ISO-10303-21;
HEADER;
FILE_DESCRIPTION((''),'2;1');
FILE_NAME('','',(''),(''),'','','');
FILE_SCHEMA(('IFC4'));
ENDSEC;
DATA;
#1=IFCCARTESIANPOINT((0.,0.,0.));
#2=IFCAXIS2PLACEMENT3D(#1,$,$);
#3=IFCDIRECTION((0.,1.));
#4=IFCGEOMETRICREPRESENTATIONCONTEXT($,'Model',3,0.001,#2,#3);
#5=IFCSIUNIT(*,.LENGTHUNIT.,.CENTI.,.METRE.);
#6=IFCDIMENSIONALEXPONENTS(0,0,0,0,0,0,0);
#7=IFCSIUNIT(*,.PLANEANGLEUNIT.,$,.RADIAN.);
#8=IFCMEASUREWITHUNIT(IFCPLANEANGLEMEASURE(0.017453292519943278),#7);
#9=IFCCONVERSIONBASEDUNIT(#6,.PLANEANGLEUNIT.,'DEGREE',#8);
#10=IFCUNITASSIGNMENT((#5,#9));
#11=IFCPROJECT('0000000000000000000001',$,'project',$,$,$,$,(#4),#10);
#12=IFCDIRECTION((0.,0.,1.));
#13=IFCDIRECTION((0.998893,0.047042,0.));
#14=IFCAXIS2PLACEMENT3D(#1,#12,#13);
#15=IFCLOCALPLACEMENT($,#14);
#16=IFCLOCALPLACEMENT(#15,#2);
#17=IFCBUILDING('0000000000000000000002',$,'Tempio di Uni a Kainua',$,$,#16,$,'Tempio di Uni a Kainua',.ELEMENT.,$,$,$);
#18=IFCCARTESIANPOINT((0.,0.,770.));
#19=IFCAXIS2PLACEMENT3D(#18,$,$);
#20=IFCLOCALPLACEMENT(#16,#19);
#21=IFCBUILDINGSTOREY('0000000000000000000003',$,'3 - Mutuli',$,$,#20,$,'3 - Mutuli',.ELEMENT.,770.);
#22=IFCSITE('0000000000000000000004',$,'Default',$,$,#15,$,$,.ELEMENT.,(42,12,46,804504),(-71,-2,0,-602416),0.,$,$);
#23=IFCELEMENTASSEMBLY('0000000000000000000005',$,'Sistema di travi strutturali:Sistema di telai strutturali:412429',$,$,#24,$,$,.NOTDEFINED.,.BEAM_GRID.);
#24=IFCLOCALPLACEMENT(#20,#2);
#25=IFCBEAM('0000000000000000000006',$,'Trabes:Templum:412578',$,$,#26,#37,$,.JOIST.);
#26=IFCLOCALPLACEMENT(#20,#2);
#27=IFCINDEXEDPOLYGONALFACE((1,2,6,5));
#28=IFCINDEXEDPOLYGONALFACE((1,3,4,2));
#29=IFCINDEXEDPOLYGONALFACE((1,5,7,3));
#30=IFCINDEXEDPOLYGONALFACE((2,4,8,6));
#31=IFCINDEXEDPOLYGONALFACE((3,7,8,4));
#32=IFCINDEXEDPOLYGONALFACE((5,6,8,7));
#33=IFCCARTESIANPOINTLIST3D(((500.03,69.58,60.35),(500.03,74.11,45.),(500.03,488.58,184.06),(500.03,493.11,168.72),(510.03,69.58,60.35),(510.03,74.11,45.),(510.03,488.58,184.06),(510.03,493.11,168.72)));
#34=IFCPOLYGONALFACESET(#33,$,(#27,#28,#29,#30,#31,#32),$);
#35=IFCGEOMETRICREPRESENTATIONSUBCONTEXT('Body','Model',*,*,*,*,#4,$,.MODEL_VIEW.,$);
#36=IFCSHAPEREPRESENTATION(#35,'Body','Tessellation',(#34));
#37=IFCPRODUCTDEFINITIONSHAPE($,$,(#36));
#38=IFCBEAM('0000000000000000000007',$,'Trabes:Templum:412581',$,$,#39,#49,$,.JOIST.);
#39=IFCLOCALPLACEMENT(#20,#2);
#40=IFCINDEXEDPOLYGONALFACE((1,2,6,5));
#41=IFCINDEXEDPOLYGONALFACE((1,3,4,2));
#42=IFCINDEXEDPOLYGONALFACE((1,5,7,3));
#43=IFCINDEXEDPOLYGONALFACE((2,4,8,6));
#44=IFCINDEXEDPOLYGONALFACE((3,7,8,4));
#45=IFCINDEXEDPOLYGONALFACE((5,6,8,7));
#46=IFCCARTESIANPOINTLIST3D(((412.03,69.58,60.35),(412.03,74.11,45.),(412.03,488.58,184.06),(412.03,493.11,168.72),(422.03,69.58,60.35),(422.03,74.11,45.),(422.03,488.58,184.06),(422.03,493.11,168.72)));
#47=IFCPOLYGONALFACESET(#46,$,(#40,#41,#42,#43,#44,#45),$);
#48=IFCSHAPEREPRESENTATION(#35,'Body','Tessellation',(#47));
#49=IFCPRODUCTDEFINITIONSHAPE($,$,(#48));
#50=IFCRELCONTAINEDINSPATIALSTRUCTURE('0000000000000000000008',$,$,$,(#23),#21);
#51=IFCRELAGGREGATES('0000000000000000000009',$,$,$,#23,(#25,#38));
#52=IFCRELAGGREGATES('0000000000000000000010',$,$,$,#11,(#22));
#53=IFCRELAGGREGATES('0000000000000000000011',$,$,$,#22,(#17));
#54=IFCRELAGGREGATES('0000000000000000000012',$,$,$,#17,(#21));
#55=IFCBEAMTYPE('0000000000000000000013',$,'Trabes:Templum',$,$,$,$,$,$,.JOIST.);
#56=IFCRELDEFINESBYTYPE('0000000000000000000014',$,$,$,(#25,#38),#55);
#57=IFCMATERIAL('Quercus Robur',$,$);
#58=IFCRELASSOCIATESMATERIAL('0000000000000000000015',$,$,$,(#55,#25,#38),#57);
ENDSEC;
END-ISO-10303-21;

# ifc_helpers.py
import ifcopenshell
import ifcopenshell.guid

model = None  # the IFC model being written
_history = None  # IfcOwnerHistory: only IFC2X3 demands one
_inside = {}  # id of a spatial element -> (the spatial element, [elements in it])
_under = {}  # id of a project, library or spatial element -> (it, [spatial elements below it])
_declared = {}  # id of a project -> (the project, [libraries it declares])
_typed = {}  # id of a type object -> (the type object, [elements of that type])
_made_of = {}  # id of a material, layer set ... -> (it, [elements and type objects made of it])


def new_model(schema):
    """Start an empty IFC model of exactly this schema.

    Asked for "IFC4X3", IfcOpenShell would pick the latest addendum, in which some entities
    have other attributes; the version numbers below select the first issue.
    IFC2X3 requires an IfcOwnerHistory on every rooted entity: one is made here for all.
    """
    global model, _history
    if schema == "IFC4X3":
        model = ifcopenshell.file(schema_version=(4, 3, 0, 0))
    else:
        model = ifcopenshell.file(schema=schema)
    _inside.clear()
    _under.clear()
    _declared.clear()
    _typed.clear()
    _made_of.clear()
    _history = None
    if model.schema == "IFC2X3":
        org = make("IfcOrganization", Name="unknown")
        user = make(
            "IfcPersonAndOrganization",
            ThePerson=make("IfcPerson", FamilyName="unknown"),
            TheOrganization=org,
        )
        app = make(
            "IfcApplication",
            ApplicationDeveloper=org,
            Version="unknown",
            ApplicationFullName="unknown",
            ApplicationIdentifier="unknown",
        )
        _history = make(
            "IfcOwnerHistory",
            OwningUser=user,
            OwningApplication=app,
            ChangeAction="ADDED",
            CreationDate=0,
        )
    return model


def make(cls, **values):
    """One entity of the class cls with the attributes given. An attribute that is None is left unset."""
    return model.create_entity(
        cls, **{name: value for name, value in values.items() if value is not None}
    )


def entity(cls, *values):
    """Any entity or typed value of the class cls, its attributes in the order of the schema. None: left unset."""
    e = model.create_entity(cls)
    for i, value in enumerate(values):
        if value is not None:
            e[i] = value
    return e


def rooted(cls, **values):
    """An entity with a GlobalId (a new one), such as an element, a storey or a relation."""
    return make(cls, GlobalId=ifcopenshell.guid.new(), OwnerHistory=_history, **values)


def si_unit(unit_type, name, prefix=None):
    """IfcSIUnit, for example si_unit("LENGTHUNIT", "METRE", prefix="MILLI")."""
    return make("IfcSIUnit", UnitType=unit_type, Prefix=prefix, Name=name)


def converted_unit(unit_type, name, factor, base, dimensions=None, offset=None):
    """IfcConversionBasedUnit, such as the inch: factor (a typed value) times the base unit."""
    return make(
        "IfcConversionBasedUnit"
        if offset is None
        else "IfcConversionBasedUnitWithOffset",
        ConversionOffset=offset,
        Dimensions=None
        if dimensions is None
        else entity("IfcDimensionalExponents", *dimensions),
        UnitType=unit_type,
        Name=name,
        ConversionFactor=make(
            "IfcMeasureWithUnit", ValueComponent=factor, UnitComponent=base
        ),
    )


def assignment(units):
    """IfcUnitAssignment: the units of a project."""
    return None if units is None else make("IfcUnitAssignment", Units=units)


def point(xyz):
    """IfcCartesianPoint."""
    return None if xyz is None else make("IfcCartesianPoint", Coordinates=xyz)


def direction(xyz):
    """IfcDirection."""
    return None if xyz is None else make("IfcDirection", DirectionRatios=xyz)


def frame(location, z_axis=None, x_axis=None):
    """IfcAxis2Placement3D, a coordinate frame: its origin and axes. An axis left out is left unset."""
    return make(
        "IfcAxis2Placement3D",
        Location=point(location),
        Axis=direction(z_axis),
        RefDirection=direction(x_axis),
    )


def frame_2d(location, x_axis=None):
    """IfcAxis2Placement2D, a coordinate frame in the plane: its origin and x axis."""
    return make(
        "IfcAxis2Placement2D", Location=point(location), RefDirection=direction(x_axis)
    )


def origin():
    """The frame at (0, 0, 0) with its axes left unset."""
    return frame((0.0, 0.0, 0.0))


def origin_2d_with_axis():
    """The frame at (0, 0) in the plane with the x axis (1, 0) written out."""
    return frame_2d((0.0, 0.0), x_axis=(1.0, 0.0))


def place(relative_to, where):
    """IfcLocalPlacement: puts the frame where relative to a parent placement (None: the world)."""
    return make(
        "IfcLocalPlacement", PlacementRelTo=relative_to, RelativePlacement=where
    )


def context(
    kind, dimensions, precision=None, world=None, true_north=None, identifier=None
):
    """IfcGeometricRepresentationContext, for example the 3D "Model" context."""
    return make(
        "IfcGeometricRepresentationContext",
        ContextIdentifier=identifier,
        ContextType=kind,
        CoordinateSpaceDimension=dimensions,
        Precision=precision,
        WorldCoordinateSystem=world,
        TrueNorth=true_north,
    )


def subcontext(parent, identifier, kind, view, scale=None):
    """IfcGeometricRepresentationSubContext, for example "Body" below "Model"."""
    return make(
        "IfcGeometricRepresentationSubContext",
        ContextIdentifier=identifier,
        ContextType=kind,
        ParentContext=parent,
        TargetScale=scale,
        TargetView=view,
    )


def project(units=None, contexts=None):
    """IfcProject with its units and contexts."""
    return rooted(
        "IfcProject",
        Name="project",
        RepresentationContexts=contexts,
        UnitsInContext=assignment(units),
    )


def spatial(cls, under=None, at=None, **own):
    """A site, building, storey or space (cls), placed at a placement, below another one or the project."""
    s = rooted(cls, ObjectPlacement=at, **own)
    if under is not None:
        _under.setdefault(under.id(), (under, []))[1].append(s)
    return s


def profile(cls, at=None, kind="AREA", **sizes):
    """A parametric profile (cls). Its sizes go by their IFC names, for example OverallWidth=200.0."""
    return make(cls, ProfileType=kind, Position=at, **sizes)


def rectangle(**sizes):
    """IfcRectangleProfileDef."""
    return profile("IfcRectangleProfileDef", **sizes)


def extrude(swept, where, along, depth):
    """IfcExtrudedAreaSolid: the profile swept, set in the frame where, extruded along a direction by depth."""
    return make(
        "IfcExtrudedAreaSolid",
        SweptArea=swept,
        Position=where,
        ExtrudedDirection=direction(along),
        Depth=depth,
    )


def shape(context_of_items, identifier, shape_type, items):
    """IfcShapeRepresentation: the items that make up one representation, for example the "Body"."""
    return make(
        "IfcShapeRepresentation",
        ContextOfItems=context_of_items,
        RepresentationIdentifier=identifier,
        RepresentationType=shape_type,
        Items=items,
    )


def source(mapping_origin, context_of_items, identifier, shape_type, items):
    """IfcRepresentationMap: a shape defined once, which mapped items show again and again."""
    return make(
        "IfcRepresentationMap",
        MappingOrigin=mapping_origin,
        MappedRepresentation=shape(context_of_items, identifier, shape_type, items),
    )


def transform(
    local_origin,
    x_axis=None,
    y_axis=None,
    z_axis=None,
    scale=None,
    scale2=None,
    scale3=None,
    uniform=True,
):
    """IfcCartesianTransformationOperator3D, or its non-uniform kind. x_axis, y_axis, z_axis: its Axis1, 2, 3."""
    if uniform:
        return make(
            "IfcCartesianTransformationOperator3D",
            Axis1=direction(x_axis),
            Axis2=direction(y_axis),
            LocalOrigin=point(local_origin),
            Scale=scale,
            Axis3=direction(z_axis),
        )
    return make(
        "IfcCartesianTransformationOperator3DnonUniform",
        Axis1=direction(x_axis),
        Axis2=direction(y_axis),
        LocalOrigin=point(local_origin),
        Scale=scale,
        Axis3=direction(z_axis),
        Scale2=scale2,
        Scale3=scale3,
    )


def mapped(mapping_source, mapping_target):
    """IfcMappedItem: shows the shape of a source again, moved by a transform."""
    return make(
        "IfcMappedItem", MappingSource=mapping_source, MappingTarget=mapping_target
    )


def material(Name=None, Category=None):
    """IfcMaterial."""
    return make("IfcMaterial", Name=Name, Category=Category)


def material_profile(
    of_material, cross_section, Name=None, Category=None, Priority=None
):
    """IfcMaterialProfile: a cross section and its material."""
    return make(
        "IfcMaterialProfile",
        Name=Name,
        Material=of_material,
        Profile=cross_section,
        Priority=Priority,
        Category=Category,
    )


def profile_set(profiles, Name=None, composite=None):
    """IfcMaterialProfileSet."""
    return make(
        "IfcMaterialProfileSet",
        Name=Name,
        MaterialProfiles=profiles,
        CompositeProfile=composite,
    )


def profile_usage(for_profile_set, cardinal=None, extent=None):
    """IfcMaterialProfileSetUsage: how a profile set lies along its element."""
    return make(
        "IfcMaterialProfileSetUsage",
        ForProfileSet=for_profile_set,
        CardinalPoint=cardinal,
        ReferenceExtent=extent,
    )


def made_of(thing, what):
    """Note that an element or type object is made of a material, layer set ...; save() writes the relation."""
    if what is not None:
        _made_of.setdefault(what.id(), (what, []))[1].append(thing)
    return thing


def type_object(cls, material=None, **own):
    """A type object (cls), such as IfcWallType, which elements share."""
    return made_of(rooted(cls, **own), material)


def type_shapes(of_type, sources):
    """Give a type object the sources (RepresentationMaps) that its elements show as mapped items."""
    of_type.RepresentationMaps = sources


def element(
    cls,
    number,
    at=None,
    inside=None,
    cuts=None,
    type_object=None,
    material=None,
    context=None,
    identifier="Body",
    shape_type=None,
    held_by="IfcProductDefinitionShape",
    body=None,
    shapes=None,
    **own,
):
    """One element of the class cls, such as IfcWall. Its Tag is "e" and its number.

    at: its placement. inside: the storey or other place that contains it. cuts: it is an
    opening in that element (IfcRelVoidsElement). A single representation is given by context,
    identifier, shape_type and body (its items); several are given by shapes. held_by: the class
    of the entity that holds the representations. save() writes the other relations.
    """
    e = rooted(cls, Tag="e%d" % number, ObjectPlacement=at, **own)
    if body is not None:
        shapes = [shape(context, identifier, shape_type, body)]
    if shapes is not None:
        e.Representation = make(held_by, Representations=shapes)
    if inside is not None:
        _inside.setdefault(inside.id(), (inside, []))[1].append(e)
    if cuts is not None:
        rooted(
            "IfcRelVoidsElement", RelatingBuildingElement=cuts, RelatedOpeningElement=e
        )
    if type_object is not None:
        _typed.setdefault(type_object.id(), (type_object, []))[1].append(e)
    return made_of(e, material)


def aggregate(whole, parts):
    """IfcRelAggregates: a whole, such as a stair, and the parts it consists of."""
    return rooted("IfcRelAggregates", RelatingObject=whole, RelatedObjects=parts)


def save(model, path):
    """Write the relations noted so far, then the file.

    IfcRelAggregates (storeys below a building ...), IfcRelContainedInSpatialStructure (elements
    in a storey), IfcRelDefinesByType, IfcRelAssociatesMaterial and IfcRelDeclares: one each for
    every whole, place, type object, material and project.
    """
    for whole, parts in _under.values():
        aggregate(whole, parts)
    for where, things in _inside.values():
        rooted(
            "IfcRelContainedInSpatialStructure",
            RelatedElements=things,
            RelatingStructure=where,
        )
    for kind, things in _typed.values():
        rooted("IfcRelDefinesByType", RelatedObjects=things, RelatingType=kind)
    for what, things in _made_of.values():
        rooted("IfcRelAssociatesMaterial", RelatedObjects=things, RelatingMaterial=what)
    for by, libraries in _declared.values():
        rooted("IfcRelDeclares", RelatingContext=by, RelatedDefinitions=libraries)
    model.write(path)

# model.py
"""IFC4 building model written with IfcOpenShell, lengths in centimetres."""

from ifc_helpers import new_model, entity, si_unit, converted_unit, direction, frame, origin, origin_2d_with_axis, place, context, subcontext, project, spatial, rectangle, extrude, source, transform, mapped, material, material_profile, profile_set, profile_usage, type_object, type_shapes, element, aggregate, save


model = new_model("IFC4")

# Units and contexts
model_context = context("Model", 3, precision=0.001, world=origin(), true_north=direction((0.0, 1.0)))
body_context = subcontext(model_context, "Body", "Model", "MODEL_VIEW")
ifc_project = project(units=[si_unit("LENGTHUNIT", "METRE", prefix="CENTI"), converted_unit("PLANEANGLEUNIT", "DEGREE", entity("IfcPlaneAngleMeasure", 0.017453292519943278), si_unit("PLANEANGLEUNIT", "RADIAN"), dimensions=[0, 0, 0, 0, 0, 0, 0])], contexts=[model_context])

# Site, building, storey
site_placement = place(None, frame((0.0, 0.0, 0.0), z_axis=(0.0, 0.0, 1.0), x_axis=(0.998893, 0.047042, 0.0)))
site = spatial("IfcSite", under=ifc_project, at=site_placement, Name="Default", CompositionType="ELEMENT", RefLatitude=(42, 12, 46, 804504), RefLongitude=(-71, -2, 0, -602416), RefElevation=0.0)
building_placement = place(site_placement, origin())
building = spatial("IfcBuilding", under=site, at=building_placement, Name="Tempio di Uni a Kainua", LongName="Tempio di Uni a Kainua", CompositionType="ELEMENT")
storey_placement = place(building_placement, frame((0.0, 0.0, 770.0)))
storey = spatial("IfcBuildingStorey", under=building, at=storey_placement, Name="3 - Mutuli", LongName="3 - Mutuli", CompositionType="ELEMENT", Elevation=770.0)

# Shared definitions
ifc_material = material(Name="Quercus Robur")

# Element assembly, beams
assembly_placement = place(storey_placement, origin())
assembly = element("IfcElementAssembly", 1, at=assembly_placement, inside=storey, Name="Sistema di travi strutturali:Sistema di telai strutturali:412429", AssemblyPlace="NOTDEFINED", PredefinedType="BEAM_GRID")
ifc_material_profile_1 = material_profile(ifc_material, rectangle(XDim=2875.46, YDim=10.0, at=origin_2d_with_axis()), Name="Templum")
ifc_profile_set_1 = profile_set([ifc_material_profile_1], Name="Templum")
ifc_profile_usage_1 = profile_usage(ifc_profile_set_1, cardinal=2)
beam_type_1 = type_object("IfcBeamType", Name="Trabes:Templum", PredefinedType="JOIST", material=ifc_profile_set_1)
shared_shape_1 = source(origin(), body_context, "Body", "SweptSolid", [
    extrude(rectangle(XDim=436.88, YDim=10.0, at=origin_2d_with_axis()), frame((0.0, 0.0, -8.0)), (0.0, 0.0, 1.0), 16.0),
])
type_shapes(beam_type_1, [shared_shape_1])
beam_1_placement = place(assembly_placement, frame((505.03, 281.34, 114.53), z_axis=(0.0, -0.283186, 0.959065), x_axis=(0.0, 0.959065, 0.283186)))
beam_1 = element("IfcBeam", 2, at=beam_1_placement, type_object=beam_type_1, material=ifc_profile_usage_1, Name="Trabes:Templum:412578", PredefinedType="JOIST", context=body_context, shape_type="MappedRepresentation", body=[
    mapped(shared_shape_1, transform((0.0, 0.0, 0.0), scale=1.0)),
])
beam_2_placement = place(assembly_placement, frame((417.03, 281.34, 114.53), z_axis=(0.0, -0.283186, 0.959065), x_axis=(0.0, 0.959065, 0.283186)))
beam_2 = element("IfcBeam", 3, at=beam_2_placement, type_object=beam_type_1, material=ifc_profile_usage_1, Name="Trabes:Templum:412581", PredefinedType="JOIST", context=body_context, shape_type="MappedRepresentation", body=[
    mapped(shared_shape_1, transform((0.0, 0.0, 0.0), scale=1.0)),
])
aggregate(assembly, [beam_1, beam_2])

save(model, "model.ifc")
